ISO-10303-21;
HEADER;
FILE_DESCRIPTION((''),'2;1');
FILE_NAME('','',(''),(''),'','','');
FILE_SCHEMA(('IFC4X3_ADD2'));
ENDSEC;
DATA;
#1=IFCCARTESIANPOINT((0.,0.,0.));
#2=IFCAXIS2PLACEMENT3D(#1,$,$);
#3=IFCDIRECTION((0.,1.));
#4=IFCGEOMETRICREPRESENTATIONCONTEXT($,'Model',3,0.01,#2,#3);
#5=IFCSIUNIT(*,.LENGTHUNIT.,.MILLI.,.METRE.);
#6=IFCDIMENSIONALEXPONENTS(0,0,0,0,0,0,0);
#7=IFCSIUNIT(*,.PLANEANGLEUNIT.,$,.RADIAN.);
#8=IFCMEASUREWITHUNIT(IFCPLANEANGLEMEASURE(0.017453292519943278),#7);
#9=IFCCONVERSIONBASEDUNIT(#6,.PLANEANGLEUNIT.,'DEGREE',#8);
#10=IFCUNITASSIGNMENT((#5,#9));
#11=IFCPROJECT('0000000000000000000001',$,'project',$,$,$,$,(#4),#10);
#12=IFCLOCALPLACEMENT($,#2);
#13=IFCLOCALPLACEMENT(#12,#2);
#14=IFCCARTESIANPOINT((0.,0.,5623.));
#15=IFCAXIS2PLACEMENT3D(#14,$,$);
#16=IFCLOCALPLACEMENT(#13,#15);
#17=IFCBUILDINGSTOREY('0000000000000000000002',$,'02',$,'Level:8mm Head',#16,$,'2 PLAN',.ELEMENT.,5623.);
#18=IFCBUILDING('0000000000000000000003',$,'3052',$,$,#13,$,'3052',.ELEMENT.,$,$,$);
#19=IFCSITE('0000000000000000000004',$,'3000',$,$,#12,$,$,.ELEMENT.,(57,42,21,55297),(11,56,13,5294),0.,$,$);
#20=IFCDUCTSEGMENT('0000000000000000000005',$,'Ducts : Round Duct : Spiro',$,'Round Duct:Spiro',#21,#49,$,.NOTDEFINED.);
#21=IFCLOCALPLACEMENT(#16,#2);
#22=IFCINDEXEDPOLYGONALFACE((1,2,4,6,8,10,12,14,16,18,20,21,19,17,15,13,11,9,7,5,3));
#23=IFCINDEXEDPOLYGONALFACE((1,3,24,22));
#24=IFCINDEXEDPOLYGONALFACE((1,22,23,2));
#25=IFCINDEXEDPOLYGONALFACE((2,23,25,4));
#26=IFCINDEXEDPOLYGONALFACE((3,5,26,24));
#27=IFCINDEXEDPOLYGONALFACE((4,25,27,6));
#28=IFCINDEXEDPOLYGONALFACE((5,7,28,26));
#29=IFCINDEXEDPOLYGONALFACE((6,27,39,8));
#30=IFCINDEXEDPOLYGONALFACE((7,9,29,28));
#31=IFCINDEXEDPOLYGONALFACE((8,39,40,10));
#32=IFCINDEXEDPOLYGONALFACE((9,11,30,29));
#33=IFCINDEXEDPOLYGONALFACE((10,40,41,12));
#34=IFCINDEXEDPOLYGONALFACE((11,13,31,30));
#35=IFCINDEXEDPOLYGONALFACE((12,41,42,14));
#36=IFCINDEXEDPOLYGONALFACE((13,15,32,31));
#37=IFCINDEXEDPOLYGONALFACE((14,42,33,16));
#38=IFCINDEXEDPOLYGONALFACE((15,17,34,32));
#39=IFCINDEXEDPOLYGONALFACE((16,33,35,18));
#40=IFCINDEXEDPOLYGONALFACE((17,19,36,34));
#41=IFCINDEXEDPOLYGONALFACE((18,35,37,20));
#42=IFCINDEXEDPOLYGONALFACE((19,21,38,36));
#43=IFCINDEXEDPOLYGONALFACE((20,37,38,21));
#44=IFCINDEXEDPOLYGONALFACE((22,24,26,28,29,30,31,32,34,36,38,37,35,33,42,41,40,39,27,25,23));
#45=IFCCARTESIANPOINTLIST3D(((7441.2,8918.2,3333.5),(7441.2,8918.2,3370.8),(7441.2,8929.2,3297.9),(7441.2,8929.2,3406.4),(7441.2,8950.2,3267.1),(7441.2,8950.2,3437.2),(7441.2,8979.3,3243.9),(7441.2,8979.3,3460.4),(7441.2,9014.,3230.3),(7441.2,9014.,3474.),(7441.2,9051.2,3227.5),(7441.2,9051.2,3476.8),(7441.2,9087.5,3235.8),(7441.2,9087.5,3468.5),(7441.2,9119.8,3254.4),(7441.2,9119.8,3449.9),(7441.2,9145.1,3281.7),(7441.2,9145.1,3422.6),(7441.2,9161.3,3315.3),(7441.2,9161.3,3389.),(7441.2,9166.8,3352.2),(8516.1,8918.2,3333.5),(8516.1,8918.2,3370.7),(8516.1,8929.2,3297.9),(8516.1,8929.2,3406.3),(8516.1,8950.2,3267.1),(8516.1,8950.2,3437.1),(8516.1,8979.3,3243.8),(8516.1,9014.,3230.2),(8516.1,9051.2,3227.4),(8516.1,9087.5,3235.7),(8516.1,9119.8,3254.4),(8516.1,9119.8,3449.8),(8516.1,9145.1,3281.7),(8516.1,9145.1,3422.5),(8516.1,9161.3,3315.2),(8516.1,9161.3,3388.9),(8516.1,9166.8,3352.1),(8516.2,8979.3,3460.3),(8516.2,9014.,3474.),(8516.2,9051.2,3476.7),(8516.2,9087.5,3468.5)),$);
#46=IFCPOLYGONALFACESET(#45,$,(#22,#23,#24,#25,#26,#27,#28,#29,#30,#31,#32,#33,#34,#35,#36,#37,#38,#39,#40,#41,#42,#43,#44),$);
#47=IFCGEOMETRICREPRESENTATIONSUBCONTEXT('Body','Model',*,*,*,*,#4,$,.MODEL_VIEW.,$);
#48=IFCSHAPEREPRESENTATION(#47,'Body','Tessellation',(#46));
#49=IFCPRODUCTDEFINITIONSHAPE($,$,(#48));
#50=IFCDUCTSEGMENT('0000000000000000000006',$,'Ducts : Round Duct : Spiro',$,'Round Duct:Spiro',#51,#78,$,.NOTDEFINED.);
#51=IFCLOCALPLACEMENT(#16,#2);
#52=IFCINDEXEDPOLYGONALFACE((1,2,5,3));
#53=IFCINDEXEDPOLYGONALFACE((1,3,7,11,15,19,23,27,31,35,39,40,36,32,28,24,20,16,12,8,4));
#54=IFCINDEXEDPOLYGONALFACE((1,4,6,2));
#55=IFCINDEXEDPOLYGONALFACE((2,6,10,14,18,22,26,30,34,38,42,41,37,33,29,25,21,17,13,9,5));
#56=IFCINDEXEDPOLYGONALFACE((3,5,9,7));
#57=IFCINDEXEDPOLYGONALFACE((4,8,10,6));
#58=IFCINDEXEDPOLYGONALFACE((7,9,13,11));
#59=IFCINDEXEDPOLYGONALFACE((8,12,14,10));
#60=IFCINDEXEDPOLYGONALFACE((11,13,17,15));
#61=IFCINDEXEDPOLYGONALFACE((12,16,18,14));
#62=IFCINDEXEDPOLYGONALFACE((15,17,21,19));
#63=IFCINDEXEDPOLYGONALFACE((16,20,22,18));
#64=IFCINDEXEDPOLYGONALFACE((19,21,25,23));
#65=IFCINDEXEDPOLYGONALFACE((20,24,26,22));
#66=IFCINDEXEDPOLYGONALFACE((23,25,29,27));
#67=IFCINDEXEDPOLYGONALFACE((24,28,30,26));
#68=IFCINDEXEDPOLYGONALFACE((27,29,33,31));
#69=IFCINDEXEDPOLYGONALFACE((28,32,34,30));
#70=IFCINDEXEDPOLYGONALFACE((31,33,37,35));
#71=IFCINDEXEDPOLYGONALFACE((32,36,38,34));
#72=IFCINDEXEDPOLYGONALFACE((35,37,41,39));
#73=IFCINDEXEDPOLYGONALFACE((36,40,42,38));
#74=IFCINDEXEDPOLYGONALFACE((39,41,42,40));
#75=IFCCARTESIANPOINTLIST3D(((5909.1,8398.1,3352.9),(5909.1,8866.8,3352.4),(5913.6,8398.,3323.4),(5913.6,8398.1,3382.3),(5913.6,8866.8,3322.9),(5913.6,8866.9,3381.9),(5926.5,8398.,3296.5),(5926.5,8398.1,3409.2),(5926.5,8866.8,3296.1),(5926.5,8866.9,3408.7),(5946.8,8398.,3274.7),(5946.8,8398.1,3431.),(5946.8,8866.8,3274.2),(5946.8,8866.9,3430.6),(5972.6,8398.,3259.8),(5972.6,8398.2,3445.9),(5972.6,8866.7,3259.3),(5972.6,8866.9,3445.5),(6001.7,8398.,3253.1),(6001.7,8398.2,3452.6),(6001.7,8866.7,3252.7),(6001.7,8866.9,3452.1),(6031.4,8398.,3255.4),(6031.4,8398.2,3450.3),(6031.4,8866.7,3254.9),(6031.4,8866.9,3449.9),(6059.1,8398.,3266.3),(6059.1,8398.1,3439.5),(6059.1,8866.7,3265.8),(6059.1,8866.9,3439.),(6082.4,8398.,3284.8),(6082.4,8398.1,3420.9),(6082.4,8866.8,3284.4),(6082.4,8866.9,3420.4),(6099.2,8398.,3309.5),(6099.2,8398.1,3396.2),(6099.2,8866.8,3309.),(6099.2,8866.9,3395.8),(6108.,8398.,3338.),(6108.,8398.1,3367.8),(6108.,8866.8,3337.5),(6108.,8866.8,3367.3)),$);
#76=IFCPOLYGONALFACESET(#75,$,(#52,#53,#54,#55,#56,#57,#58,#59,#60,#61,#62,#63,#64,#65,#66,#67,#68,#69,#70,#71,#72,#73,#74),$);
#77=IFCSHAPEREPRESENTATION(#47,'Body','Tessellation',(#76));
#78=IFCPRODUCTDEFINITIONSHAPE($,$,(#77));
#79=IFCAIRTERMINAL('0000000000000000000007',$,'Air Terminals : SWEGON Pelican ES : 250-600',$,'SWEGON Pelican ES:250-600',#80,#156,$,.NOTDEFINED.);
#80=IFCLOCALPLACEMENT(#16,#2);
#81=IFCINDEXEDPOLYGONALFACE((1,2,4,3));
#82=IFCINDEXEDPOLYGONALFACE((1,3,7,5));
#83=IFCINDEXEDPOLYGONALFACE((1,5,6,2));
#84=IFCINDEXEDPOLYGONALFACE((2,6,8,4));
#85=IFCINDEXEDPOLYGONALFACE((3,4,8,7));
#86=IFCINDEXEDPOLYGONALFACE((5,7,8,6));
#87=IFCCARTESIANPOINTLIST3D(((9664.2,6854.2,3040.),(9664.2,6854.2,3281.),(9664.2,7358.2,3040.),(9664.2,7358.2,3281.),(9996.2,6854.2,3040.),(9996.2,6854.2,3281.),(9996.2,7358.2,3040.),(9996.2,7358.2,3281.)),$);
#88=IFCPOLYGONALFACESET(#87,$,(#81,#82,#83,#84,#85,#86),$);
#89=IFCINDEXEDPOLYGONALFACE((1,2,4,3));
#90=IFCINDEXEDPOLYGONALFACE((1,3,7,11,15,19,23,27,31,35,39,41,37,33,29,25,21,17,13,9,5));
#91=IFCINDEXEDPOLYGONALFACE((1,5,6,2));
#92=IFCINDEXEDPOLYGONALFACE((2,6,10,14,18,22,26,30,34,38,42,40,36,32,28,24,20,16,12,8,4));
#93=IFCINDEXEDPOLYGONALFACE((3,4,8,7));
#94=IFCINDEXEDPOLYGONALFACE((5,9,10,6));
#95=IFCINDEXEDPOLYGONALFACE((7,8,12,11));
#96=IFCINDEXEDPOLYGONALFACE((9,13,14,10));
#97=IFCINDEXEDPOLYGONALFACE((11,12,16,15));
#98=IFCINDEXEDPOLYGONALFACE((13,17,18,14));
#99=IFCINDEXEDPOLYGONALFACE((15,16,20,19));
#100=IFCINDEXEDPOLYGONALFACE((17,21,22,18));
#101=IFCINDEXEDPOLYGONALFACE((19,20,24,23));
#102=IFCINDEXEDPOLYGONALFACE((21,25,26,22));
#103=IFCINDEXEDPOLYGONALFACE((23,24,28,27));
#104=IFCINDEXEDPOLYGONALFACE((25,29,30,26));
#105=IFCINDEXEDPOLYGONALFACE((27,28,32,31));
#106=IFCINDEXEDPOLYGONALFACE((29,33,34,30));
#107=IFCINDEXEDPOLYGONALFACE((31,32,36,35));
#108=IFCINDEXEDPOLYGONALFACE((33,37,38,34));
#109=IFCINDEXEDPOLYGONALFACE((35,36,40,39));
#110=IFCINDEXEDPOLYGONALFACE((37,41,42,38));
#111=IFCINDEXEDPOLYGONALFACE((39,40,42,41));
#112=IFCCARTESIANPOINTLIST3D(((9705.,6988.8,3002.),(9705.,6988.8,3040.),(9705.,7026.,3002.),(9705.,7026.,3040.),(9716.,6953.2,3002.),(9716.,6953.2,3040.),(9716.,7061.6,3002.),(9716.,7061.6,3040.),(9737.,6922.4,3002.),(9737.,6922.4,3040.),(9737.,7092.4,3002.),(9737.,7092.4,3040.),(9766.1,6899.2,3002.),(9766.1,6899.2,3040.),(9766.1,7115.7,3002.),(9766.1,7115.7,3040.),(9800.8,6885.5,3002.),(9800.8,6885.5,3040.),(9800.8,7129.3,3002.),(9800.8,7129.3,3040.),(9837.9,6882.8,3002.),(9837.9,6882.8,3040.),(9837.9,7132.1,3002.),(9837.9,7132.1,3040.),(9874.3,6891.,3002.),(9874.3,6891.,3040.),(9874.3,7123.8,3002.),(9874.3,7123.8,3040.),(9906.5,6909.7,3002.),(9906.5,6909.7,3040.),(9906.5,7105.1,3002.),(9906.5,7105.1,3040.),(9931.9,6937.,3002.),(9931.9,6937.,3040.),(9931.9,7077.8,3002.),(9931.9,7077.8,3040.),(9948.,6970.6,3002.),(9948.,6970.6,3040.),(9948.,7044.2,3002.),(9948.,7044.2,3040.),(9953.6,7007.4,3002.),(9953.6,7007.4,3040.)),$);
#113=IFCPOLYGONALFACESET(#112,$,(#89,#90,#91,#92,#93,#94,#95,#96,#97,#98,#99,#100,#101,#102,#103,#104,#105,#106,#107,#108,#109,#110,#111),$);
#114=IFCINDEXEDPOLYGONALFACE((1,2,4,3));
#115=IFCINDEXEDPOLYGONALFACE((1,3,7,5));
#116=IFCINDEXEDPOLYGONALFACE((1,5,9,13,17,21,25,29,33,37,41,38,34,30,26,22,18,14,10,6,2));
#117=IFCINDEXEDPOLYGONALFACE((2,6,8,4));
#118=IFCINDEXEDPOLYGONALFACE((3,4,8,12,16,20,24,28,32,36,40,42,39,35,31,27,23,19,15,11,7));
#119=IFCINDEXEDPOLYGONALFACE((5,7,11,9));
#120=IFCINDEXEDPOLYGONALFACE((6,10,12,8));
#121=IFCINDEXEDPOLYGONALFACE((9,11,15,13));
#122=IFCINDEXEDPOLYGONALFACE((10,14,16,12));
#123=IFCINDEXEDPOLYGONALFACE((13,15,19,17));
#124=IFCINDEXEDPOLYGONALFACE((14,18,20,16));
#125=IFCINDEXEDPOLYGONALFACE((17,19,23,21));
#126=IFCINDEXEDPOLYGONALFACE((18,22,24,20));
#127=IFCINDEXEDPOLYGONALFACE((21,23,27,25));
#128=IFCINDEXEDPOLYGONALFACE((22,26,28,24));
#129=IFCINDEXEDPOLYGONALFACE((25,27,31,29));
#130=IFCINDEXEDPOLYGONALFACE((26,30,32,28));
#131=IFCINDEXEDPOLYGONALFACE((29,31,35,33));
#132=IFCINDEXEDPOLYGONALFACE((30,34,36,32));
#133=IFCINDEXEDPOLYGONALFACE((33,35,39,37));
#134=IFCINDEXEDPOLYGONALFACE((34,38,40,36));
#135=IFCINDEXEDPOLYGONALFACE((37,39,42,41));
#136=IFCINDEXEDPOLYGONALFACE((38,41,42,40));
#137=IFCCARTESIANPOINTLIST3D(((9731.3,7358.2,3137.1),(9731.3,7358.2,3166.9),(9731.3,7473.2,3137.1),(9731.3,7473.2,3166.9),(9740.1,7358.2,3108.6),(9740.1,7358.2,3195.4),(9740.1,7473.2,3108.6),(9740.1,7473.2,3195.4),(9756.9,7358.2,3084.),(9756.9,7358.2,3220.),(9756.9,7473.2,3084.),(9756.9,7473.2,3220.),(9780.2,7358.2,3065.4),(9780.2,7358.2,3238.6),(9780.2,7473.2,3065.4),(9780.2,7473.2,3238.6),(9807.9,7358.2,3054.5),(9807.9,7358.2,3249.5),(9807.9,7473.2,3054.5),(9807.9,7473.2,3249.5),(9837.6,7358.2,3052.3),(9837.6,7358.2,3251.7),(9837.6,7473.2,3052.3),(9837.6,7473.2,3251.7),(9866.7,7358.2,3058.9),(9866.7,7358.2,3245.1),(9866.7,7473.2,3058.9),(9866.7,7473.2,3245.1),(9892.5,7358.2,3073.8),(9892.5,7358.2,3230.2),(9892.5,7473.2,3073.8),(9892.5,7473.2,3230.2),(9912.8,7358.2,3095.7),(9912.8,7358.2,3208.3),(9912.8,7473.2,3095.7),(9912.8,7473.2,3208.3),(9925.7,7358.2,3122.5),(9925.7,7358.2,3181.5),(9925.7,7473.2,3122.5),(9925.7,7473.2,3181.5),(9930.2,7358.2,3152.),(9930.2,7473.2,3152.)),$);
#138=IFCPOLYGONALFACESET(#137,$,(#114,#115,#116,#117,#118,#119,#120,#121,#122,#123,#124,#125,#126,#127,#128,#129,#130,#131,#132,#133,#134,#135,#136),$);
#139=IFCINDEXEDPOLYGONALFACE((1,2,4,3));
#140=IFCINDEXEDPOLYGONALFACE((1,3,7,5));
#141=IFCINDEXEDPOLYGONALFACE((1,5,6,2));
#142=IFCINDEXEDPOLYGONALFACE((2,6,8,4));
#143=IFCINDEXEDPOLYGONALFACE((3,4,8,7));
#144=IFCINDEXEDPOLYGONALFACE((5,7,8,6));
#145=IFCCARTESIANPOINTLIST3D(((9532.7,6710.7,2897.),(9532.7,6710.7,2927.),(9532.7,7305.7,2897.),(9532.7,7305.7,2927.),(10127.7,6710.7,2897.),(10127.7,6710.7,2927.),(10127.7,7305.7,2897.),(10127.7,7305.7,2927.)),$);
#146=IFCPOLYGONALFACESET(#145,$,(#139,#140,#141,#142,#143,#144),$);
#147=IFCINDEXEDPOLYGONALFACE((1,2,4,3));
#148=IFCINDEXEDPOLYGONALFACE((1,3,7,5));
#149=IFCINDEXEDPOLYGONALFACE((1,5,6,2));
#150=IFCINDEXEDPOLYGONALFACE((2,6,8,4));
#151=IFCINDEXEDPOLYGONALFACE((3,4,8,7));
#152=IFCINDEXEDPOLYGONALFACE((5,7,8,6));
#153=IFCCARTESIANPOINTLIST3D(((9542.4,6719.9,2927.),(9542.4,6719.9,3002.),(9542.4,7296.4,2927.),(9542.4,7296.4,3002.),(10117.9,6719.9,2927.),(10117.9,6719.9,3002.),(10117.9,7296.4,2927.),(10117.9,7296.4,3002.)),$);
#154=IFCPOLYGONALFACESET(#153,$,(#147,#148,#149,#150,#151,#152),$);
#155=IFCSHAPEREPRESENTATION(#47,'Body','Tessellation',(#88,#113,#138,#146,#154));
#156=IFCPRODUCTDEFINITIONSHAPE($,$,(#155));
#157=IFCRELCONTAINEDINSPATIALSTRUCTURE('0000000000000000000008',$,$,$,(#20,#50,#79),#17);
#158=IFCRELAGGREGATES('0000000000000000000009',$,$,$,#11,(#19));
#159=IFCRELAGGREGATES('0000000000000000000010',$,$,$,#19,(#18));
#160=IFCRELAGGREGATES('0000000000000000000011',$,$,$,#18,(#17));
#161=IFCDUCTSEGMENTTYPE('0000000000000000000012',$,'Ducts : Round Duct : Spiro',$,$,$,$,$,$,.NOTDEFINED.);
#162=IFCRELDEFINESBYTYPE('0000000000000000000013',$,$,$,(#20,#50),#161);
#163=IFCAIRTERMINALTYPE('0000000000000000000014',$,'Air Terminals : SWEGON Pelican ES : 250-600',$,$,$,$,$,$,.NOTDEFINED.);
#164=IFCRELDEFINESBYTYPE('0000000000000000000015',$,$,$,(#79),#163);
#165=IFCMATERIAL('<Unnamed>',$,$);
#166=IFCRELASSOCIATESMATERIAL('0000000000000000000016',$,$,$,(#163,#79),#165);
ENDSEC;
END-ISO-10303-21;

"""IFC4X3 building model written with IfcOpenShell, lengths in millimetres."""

from ifc_helpers import new_model, entity, si_unit, converted_unit, direction, frame, frame_2d, origin, origin_2d_with_axis, place, context, subcontext, project, spatial, rectangle, circle, extrude, source, transform, mapped, material, type_object, type_shapes, element, save


model = new_model("IFC4X3")

# Units and contexts
model_context = context("Model", 3, precision=0.01, world=origin(), true_north=direction((0.0, 1.0)))
body_context = subcontext(model_context, "Body", "Model", "MODEL_VIEW")
ifc_project = project(units=[si_unit("LENGTHUNIT", "METRE", prefix="MILLI"), converted_unit("PLANEANGLEUNIT", "DEGREE", entity("IfcPlaneAngleMeasure", 0.017453292519943278), si_unit("PLANEANGLEUNIT", "RADIAN"), dimensions=[0, 0, 0, 0, 0, 0, 0])], contexts=[model_context])

# Site, building, storey
site_placement = place(None, origin())
site = spatial("IfcSite", under=ifc_project, at=site_placement, Name="3000", CompositionType="ELEMENT", RefLatitude=(57, 42, 21, 55297), RefLongitude=(11, 56, 13, 5294), RefElevation=0.0)
building_placement = place(site_placement, origin())
building = spatial("IfcBuilding", under=site, at=building_placement, Name="3052", LongName="3052", CompositionType="ELEMENT")
storey_placement = place(building_placement, frame((0.0, 0.0, 5623.0)))
storey = spatial("IfcBuildingStorey", under=building, at=storey_placement, Name="02", ObjectType="Level:8mm Head", LongName="2 PLAN", CompositionType="ELEMENT", Elevation=5623.0)

# Duct segments
duct_segment_type = type_object("IfcDuctSegmentType", Name="Ducts : Round Duct : Spiro", PredefinedType="NOTDEFINED")
duct_segment_1_placement = place(storey_placement, frame((7441.2, 8915.2, 3478.7)))
element("IfcDuctSegment", 1, at=duct_segment_1_placement, inside=storey, type_object=duct_segment_type, Name="Ducts : Round Duct : Spiro", ObjectType="Round Duct:Spiro", PredefinedType="NOTDEFINED", context=body_context, shape_type="SweptSolid", body=[
    extrude(circle(Radius=125.0, at=frame_2d((0.0, 0.0), x_axis=(1.0, 0.0))), frame((1075.0, 126.6, -126.7), z_axis=(-1.0, 0.0, 0.000055), x_axis=(0.0, 1.0, 0.0)), (0.0, 0.0, 1.0), 1075.0),
])
duct_segment_2_placement = place(storey_placement, frame((5907.5, 8398.0, 3250.8)))
element("IfcDuctSegment", 2, at=duct_segment_2_placement, inside=storey, type_object=duct_segment_type, Name="Ducts : Round Duct : Spiro", ObjectType="Round Duct:Spiro", PredefinedType="NOTDEFINED", context=body_context, shape_type="SweptSolid", body=[
    extrude(circle(Radius=100.0, at=frame_2d((0.0, 0.0), x_axis=(1.0, 0.0))), frame((101.6, 0.1, 102.1), z_axis=(0.0, 1.0, -0.000973), x_axis=(-1.0, 0.0, 0.0)), (0.0, 0.0, 1.0), 468.8),
])

# Shared definitions
ifc_material_1 = material(Name="<Unnamed>")

# Air terminal
air_terminal_type_1 = type_object("IfcAirTerminalType", Name="Air Terminals : SWEGON Pelican ES : 250-600", PredefinedType="NOTDEFINED", material=ifc_material_1)
shared_shape_1 = source(origin(), body_context, "Body", "SweptSolid", [
    extrude(rectangle(XDim=504.0, YDim=332.0, at=origin_2d_with_axis()), frame((0.0, -98.0, -354.0), z_axis=(0.0, 0.0, 1.0), x_axis=(0.0, 1.0, 0.0)), (0.0, 0.0, 1.0), 241.0),
    extrude(circle(Radius=125.0, at=frame_2d((0.0, 0.0), x_axis=(1.0, 0.0))), frame((-1.6, 0.8, -113.0)), (0.0, 0.0, 1.0), 38.0),
    extrude(circle(Radius=100.0, at=frame_2d((0.0, 0.0), x_axis=(1.0, 0.0))), frame((0.0, -465.0, -225.0), z_axis=(0.0, 1.0, 0.0), x_axis=(1.0, 0.0, 0.0)), (0.0, 0.0, 1.0), 115.0),
    extrude(rectangle(XDim=595.0, YDim=595.0, at=frame_2d((0.0, 0.0), x_axis=(1.0, 0.0))), frame((0.0, 0.0, 0.0), z_axis=(0.0, 0.0, 1.0), x_axis=(0.0, 1.0, 0.0)), (0.0, 0.0, 1.0), 30.0),
    extrude(rectangle(XDim=576.5, YDim=575.5, at=origin_2d_with_axis()), frame((0.0, 0.0, -75.0), z_axis=(0.0, 0.0, 1.0), x_axis=(0.0, 1.0, 0.0)), (0.0, 0.0, 1.0), 75.0),
])
type_shapes(air_terminal_type_1, [shared_shape_1])
for number, where, z_axis, x_axis, name in (
    (3, (9830.2, 7008.2, 2927.0), (0.0, 0.0, -1.0), (1.0, 0.0, 0.0), "Air Terminals : SWEGON Pelican ES : 250-600"),
):
    element("IfcAirTerminal", number, at=place(storey_placement, frame(where, z_axis=z_axis, x_axis=x_axis)), inside=storey, type_object=air_terminal_type_1, material=ifc_material_1, Name=name, ObjectType="SWEGON Pelican ES:250-600", PredefinedType="NOTDEFINED", context=body_context, shape_type="MappedRepresentation", body=[
        mapped(shared_shape_1, transform((0.0, 0.0, 0.0), scale=1.0)),
    ])

save(model, "model.ifc")
